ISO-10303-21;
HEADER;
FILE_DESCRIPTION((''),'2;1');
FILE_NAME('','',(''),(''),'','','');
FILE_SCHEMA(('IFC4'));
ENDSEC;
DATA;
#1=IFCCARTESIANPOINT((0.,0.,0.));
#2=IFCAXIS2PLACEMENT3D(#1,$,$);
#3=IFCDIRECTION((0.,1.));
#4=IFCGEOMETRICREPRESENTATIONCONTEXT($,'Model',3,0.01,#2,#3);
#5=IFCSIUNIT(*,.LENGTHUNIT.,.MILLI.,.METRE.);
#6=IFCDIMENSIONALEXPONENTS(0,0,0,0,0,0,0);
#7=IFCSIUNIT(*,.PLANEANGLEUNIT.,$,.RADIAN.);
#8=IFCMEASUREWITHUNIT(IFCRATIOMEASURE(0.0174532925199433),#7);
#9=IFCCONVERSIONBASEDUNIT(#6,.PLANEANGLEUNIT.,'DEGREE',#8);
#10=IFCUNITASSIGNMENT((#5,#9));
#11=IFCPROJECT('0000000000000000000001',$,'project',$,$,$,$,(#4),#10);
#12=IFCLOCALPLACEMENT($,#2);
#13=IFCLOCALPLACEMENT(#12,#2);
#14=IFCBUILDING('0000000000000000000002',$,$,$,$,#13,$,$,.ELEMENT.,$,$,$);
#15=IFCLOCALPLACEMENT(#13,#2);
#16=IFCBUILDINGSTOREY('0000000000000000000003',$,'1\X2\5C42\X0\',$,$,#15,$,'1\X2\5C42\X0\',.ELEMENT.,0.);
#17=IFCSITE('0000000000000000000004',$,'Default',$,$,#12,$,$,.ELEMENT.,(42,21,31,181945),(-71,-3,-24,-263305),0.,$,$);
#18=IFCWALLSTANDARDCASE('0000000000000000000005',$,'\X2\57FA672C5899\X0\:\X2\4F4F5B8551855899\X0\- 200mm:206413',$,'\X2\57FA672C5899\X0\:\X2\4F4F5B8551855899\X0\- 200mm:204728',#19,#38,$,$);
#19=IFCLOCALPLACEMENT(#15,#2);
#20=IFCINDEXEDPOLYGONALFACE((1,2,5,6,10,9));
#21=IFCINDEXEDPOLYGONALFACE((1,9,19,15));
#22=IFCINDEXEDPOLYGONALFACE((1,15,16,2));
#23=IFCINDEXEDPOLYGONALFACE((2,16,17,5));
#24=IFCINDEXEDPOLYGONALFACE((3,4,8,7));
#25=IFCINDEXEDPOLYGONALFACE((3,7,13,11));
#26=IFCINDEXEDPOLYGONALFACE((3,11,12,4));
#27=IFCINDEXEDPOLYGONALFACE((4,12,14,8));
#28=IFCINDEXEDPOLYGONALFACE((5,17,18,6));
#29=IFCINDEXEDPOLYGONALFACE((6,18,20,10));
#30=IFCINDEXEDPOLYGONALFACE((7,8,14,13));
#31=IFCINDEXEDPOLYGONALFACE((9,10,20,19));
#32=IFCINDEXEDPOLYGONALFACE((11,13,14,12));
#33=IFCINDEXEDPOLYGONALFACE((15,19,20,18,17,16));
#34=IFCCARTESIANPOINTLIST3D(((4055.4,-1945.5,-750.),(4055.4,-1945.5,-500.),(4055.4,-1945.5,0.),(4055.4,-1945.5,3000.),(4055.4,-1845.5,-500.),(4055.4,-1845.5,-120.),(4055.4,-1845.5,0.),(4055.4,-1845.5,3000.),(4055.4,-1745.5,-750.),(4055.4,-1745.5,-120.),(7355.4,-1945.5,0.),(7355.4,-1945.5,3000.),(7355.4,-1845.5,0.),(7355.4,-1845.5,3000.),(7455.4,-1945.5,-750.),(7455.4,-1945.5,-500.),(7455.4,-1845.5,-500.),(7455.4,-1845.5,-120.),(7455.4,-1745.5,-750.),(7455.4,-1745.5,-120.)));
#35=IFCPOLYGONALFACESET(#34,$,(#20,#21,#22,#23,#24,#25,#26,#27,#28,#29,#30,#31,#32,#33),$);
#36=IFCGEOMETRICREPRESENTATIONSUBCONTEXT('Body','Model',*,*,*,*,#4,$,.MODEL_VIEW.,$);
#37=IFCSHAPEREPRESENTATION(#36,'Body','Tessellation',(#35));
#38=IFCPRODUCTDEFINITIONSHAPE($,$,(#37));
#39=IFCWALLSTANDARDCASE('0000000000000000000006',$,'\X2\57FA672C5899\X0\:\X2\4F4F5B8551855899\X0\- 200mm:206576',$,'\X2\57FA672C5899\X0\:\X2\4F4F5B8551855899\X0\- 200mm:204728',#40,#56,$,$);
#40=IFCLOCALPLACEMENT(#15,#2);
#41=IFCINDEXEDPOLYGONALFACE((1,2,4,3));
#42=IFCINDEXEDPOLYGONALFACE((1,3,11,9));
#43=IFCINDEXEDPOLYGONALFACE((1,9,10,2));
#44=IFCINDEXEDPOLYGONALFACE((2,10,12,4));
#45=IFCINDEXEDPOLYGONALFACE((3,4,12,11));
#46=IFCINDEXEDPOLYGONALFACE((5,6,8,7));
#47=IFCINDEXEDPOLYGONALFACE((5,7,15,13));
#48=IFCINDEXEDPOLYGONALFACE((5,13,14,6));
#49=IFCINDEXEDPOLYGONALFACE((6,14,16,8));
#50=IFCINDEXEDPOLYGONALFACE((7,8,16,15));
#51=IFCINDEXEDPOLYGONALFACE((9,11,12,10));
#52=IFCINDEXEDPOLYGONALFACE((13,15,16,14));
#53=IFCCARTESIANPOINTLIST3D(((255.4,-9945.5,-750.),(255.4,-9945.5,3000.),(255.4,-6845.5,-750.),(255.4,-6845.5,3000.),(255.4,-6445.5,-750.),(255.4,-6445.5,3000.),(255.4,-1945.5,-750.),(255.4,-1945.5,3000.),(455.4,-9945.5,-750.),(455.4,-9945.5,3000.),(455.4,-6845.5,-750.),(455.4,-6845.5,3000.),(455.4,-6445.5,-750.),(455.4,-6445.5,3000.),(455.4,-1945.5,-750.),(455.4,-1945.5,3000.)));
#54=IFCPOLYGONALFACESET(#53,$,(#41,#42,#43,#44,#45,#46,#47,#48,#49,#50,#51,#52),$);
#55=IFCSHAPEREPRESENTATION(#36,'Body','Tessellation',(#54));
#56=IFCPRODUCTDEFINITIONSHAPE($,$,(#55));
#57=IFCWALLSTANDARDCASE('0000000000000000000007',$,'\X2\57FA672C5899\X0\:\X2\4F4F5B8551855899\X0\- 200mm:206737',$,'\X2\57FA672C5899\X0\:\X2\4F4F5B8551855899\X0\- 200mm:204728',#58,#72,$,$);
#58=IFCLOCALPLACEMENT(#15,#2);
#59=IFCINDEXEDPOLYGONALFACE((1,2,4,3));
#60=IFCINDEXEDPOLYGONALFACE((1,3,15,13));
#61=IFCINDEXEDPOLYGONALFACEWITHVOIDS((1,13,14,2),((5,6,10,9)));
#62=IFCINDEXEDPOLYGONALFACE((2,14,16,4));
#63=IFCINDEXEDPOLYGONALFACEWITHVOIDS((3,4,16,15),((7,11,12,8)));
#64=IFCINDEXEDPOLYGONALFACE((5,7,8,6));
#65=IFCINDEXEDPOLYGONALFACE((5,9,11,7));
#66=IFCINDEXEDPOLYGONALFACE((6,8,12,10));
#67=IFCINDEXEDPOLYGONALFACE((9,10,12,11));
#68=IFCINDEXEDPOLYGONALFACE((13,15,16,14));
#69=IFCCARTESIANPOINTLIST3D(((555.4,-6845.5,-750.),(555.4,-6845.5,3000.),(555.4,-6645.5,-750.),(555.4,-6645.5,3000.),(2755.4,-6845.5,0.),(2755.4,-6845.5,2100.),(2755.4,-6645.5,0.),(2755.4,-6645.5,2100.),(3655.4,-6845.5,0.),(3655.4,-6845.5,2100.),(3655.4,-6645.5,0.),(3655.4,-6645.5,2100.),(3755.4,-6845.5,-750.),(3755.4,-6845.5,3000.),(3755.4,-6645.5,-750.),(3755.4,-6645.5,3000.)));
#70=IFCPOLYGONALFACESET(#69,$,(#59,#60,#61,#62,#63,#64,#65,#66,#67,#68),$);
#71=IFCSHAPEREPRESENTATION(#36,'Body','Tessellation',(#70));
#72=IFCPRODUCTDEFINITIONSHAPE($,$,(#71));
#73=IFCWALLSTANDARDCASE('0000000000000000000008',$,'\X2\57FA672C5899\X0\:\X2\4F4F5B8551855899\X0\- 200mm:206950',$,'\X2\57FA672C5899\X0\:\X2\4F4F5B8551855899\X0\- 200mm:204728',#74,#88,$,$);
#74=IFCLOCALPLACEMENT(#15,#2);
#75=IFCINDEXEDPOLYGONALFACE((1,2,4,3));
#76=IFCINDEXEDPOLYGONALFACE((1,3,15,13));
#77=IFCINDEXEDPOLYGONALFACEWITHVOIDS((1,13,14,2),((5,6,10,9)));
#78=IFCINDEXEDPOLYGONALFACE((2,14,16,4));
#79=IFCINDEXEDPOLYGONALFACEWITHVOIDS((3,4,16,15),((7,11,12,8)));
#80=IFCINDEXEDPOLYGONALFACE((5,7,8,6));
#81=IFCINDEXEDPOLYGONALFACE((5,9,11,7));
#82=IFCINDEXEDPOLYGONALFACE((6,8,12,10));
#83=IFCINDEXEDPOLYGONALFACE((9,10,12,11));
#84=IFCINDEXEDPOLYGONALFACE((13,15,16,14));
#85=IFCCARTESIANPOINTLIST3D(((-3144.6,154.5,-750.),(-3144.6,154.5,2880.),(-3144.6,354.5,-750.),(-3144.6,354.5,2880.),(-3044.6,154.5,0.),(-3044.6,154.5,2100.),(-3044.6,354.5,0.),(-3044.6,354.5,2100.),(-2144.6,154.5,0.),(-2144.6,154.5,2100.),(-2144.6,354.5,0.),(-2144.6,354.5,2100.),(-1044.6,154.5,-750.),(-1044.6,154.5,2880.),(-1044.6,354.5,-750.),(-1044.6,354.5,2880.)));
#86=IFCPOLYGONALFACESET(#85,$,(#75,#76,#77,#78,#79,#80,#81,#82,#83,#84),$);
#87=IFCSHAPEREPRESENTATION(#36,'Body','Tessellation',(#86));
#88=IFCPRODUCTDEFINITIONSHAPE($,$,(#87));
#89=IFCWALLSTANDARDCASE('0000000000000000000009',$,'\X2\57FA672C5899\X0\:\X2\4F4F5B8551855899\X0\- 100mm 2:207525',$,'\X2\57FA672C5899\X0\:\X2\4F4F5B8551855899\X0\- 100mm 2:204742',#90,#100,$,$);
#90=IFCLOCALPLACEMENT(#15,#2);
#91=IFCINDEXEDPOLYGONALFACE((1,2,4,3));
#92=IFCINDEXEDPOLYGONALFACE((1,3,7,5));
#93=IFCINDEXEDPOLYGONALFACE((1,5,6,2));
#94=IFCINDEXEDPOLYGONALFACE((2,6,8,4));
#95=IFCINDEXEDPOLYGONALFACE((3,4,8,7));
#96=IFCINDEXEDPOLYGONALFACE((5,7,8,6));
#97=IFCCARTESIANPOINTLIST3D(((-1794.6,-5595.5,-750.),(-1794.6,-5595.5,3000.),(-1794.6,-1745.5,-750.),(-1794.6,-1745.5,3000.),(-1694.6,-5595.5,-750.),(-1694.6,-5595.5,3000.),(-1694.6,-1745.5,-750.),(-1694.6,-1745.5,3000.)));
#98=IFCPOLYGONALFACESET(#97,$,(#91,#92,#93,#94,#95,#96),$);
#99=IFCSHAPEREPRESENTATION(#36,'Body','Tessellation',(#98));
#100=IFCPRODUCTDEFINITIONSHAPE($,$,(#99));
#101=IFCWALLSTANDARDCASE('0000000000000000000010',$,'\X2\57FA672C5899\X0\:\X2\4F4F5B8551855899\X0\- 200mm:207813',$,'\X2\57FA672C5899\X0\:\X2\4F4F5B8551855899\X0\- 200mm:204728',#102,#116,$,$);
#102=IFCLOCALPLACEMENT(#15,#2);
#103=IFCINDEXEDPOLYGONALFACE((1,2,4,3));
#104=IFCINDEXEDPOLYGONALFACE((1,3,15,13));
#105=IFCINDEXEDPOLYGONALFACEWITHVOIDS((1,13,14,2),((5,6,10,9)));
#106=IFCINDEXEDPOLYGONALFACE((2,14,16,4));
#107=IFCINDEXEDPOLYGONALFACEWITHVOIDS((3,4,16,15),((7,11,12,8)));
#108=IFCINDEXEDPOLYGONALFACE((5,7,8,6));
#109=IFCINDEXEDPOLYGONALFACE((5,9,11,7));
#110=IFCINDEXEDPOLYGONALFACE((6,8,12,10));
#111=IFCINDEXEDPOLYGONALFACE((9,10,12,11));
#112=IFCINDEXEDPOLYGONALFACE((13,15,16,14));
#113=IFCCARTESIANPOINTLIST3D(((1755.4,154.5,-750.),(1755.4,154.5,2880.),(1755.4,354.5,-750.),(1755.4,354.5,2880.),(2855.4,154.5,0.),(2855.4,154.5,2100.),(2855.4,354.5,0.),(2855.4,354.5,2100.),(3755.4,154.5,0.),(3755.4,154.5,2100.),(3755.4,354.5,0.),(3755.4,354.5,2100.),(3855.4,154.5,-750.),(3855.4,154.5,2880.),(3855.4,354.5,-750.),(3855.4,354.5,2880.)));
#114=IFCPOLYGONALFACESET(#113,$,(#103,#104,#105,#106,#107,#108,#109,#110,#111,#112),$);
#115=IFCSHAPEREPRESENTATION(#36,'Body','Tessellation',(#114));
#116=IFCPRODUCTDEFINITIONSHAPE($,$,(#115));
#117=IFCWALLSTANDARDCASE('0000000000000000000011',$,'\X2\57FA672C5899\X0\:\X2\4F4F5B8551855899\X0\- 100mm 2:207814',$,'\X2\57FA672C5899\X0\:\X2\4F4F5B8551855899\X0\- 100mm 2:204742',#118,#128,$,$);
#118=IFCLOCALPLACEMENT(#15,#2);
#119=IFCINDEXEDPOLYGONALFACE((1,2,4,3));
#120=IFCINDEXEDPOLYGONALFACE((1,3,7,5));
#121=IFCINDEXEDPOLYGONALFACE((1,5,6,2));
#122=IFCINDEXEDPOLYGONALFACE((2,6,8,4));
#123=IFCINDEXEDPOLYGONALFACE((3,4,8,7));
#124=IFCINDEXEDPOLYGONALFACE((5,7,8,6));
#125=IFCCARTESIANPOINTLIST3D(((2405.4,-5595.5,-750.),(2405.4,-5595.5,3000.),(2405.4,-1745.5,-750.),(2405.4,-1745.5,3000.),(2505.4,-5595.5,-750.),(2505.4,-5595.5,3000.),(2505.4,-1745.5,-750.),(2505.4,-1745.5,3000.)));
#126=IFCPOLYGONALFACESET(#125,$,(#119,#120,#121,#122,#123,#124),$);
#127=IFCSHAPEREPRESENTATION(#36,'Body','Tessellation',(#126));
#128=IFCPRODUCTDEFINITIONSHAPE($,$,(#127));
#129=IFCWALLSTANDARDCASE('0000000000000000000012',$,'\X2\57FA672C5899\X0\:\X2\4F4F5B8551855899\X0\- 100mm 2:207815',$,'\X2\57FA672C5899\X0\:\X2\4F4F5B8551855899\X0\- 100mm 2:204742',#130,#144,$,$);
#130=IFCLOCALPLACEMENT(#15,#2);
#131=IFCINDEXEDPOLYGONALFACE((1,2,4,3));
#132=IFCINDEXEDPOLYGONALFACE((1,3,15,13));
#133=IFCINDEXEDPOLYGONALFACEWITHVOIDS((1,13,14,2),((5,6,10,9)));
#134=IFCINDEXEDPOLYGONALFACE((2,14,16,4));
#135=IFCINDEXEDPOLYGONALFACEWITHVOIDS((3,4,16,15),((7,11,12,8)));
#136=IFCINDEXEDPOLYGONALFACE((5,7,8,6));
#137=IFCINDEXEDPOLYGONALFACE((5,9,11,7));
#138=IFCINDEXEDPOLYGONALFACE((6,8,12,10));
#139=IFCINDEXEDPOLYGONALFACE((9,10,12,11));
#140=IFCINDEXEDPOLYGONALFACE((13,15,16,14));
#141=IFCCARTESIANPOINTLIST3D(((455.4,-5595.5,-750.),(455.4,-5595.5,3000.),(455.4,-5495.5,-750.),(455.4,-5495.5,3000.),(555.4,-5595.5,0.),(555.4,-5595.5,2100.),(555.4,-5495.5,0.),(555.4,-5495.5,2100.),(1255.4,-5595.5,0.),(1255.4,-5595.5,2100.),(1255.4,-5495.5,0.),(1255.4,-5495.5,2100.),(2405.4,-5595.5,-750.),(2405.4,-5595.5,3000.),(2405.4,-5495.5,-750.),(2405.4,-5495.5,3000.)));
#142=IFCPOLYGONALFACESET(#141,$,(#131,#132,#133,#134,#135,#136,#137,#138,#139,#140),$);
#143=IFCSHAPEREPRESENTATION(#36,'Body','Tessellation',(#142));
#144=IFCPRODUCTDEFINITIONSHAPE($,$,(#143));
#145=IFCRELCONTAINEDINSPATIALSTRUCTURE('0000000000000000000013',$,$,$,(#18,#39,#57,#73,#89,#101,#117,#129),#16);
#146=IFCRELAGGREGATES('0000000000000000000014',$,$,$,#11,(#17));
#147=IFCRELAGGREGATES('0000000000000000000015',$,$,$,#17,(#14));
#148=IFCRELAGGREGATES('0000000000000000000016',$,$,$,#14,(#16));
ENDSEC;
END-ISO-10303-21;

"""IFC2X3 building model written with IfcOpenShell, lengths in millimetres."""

from ifc_helpers import new_model, entity, si_unit, converted_unit, direction, frame, frame_2d, origin, place, context, subcontext, project, spatial, polyline, rectangle, extrude, clip, bounded_halfspace, element, save


model = new_model("IFC2X3")

# Units and contexts
model_context = context("Model", 3, precision=0.01, world=origin(), true_north=direction((0.0, 1.0)))
body_context = subcontext(model_context, "Body", "Model", "MODEL_VIEW")
ifc_project = project(units=[si_unit("LENGTHUNIT", "METRE", prefix="MILLI"), converted_unit("PLANEANGLEUNIT", "DEGREE", entity("IfcRatioMeasure", 0.0174532925199433), si_unit("PLANEANGLEUNIT", "RADIAN"), dimensions=[0, 0, 0, 0, 0, 0, 0])], contexts=[model_context])

# Site, building, storey
site_placement = place(None, origin())
site = spatial("IfcSite", under=ifc_project, at=site_placement, Name="Default", CompositionType="ELEMENT", RefLatitude=(42, 21, 31, 181945), RefLongitude=(-71, -3, -24, -263305), RefElevation=0.0)
building_placement = place(site_placement, origin())
building = spatial("IfcBuilding", under=site, at=building_placement, CompositionType="ELEMENT")
storey_placement = place(building_placement, origin())
storey = spatial("IfcBuildingStorey", under=building, at=storey_placement, Name="1层", LongName="1层", CompositionType="ELEMENT", Elevation=0.0)

# Walls, openings
wall_1_placement = place(storey_placement, frame((4055.4, -1845.5, -750.0)))
wall_1 = element("IfcWallStandardCase", 1, at=wall_1_placement, inside=storey, Name="基本墙:住宅内墙- 200mm:206413", ObjectType="基本墙:住宅内墙- 200mm:204728", context=body_context, shape_type="Clipping", body=[
    clip(clip(extrude(rectangle(XDim=3400.0, YDim=200.0, at=frame_2d((1700.0, 0.0), x_axis=(-1.0, 0.0))), origin(), (0.0, 0.0, 1.0), 3750.0), bounded_halfspace(frame((3300.0, -100.0, 3750.0), z_axis=(-1.0, 0.0, 0.0), x_axis=(0.0, 0.0, -1.0)), True, frame((3300.0, -100.0, 3750.0), z_axis=(-1.0, 0.0, 0.0), x_axis=(0.0, 0.0, -1.0)), polyline([(0.0, 0.0), (0.0, -200.0), (3000.0, -200.0), (3000.0, 0.0), (0.0, 0.0)]))), bounded_halfspace(frame((3400.0, 100.0, 630.0), z_axis=(0.0, 0.0, -1.0), x_axis=(1.0, 0.0, 0.0)), True, frame((3400.0, 100.0, 630.0), z_axis=(0.0, 0.0, -1.0), x_axis=(1.0, 0.0, 0.0)), polyline([(0.0, 0.0), (0.0, 100.0), (-3400.0, 100.0), (-3400.0, 0.0), (0.0, 0.0)]))),
])
opening_1_placement = place(storey_placement, frame((4055.4, -1845.5, -750.0)))
element("IfcOpeningElement", 2, at=opening_1_placement, cuts=wall_1, ObjectType="Opening", context=body_context, shape_type="SweptSolid", body=[
    extrude(rectangle(XDim=3400.0, YDim=100.0, at=frame_2d((0.0, 0.0), x_axis=(1.0, 0.0))), frame((1700.0, -50.0, 250.0), z_axis=(0.0, 0.0, 1.0), x_axis=(-1.0, 0.0, 0.0)), (0.0, 0.0, 1.0), 500.0),
])
wall_2_placement = place(storey_placement, frame((355.4, -1945.5, -750.0), z_axis=(0.0, 0.0, 1.0), x_axis=(0.0, -1.0, 0.0)))
wall_2 = element("IfcWallStandardCase", 3, at=wall_2_placement, inside=storey, Name="基本墙:住宅内墙- 200mm:206576", ObjectType="基本墙:住宅内墙- 200mm:204728", context=body_context, shape_type="Clipping", body=[
    clip(extrude(rectangle(XDim=8000.0, YDim=200.0, at=frame_2d((4000.0, 0.0), x_axis=(-1.0, 0.0))), origin(), (0.0, 0.0, 1.0), 3750.0), bounded_halfspace(frame((8000.0, -100.0, 3750.0), z_axis=(-1.0, 0.0, 0.0), x_axis=(0.0, 0.0, -1.0)), True, frame((8000.0, -100.0, 3750.0), z_axis=(-1.0, 0.0, 0.0), x_axis=(0.0, 0.0, -1.0)), polyline([(0.0, 0.0), (0.0, -200.0), (3750.0, -200.0), (3750.0, 0.0), (0.0, 0.0)]))),
])
opening_2_placement = place(storey_placement, frame((355.4, -1945.5, -750.0), z_axis=(0.0, 0.0, 1.0), x_axis=(0.0, -1.0, 0.0)))
element("IfcOpeningElement", 4, at=opening_2_placement, cuts=wall_2, ObjectType="Opening", context=body_context, shape_type="SweptSolid", body=[
    extrude(rectangle(XDim=3750.0, YDim=200.0, at=frame_2d((0.0, 0.0), x_axis=(1.0, 0.0))), frame((4900.0, 0.0, 1875.0), z_axis=(-1.0, 0.0, 0.0), x_axis=(0.0, 0.0, 1.0)), (0.0, 0.0, 1.0), 400.0),
])
wall_3_placement = place(storey_placement, frame((3755.4, -6745.5, -750.0), z_axis=(0.0, 0.0, 1.0), x_axis=(-1.0, 0.0, 0.0)))
wall_3 = element("IfcWallStandardCase", 5, at=wall_3_placement, inside=storey, Name="基本墙:住宅内墙- 200mm:206737", ObjectType="基本墙:住宅内墙- 200mm:204728", context=body_context, shape_type="Clipping", body=[
    clip(clip(extrude(rectangle(XDim=3200.0, YDim=200.0, at=frame_2d((1600.0, 0.0), x_axis=(-1.0, 0.0))), origin(), (0.0, 0.0, 1.0), 3750.0), bounded_halfspace(frame((0.0, -100.0, 0.0), z_axis=(-1.0, 0.0, 0.0), x_axis=(0.0, 0.0, -1.0)), False, frame((0.0, -100.0, 0.0), z_axis=(-1.0, 0.0, 0.0), x_axis=(0.0, 0.0, -1.0)), polyline([(0.0, 0.0), (-3750.0, 0.0), (-3750.0, -200.0), (0.0, -200.0), (0.0, 0.0)]))), bounded_halfspace(frame((3200.0, -100.0, 3750.0), z_axis=(-1.0, 0.0, 0.0), x_axis=(0.0, 0.0, -1.0)), True, frame((3200.0, -100.0, 3750.0), z_axis=(-1.0, 0.0, 0.0), x_axis=(0.0, 0.0, -1.0)), polyline([(0.0, 0.0), (0.0, -200.0), (3750.0, -200.0), (3750.0, 0.0), (0.0, 0.0)]))),
])
opening_3_placement = place(wall_3_placement, frame((100.0, -100.0, 750.0)))
element("IfcOpeningElement", 6, at=opening_3_placement, cuts=wall_3, ObjectType="Opening", context=body_context, shape_type="SweptSolid", body=[
    extrude(rectangle(XDim=2100.0, YDim=900.0, at=frame_2d((1050.0, 450.0), x_axis=(1.0, 0.0))), frame((0.0, 0.0, 0.0), z_axis=(0.0, 1.0, 0.0), x_axis=(0.0, 0.0, 1.0)), (0.0, 0.0, 1.0), 200.0),
])
wall_4_placement = place(storey_placement, frame((-3144.6, 254.5, -750.0)))
wall_4 = element("IfcWallStandardCase", 7, at=wall_4_placement, inside=storey, Name="基本墙:住宅内墙- 200mm:206950", ObjectType="基本墙:住宅内墙- 200mm:204728", context=body_context, shape_type="SweptSolid", body=[
    extrude(rectangle(XDim=2100.0, YDim=200.0, at=frame_2d((1050.0, 0.0), x_axis=(-1.0, 0.0))), origin(), (0.0, 0.0, 1.0), 3630.0),
])
opening_4_placement = place(wall_4_placement, frame((100.0, -100.0, 750.0)))
element("IfcOpeningElement", 8, at=opening_4_placement, cuts=wall_4, ObjectType="Opening", context=body_context, shape_type="SweptSolid", body=[
    extrude(rectangle(XDim=2100.0, YDim=900.0, at=frame_2d((1050.0, 450.0), x_axis=(1.0, 0.0))), frame((0.0, 0.0, 0.0), z_axis=(0.0, 1.0, 0.0), x_axis=(0.0, 0.0, 1.0)), (0.0, 0.0, 1.0), 200.0),
])

# Wall
wall_5_placement = place(storey_placement, frame((-1744.6, -1745.5, -750.0), z_axis=(0.0, 0.0, 1.0), x_axis=(0.0, -1.0, 0.0)))
element("IfcWallStandardCase", 9, at=wall_5_placement, inside=storey, Name="基本墙:住宅内墙- 100mm 2:207525", ObjectType="基本墙:住宅内墙- 100mm 2:204742", context=body_context, shape_type="SweptSolid", body=[
    extrude(rectangle(XDim=3850.0, YDim=100.0, at=frame_2d((1925.0, 0.0), x_axis=(-1.0, 0.0))), origin(), (0.0, 0.0, 1.0), 3750.0),
])

# Wall, opening
wall_6_placement = place(storey_placement, frame((3855.4, 254.5, -750.0), z_axis=(0.0, 0.0, 1.0), x_axis=(-1.0, 0.0, 0.0)))
wall_6 = element("IfcWallStandardCase", 10, at=wall_6_placement, inside=storey, Name="基本墙:住宅内墙- 200mm:207813", ObjectType="基本墙:住宅内墙- 200mm:204728", context=body_context, shape_type="SweptSolid", body=[
    extrude(rectangle(XDim=2100.0, YDim=200.0, at=frame_2d((1050.0, 0.0), x_axis=(-1.0, 0.0))), origin(), (0.0, 0.0, 1.0), 3630.0),
])
opening_5_placement = place(wall_6_placement, frame((1000.0, 100.0, 750.0)))
element("IfcOpeningElement", 11, at=opening_5_placement, cuts=wall_6, ObjectType="Opening", context=body_context, shape_type="SweptSolid", body=[
    extrude(rectangle(XDim=2100.0, YDim=900.0, at=frame_2d((1050.0, 450.0), x_axis=(1.0, 0.0))), frame((0.0, 0.0, 0.0), z_axis=(0.0, -1.0, 0.0), x_axis=(0.0, 0.0, 1.0)), (0.0, 0.0, 1.0), 200.0),
])

# Wall
wall_7_placement = place(storey_placement, frame((2455.4, -1745.5, -750.0), z_axis=(0.0, 0.0, 1.0), x_axis=(0.0, -1.0, 0.0)))
element("IfcWallStandardCase", 12, at=wall_7_placement, inside=storey, Name="基本墙:住宅内墙- 100mm 2:207814", ObjectType="基本墙:住宅内墙- 100mm 2:204742", context=body_context, shape_type="SweptSolid", body=[
    extrude(rectangle(XDim=3850.0, YDim=100.0, at=frame_2d((1925.0, 0.0), x_axis=(-1.0, 0.0))), origin(), (0.0, 0.0, 1.0), 3750.0),
])

# Wall, opening
wall_8_placement = place(storey_placement, frame((2405.4, -5545.5, -750.0), z_axis=(0.0, 0.0, 1.0), x_axis=(-1.0, 0.0, 0.0)))
wall_8 = element("IfcWallStandardCase", 13, at=wall_8_placement, inside=storey, Name="基本墙:住宅内墙- 100mm 2:207815", ObjectType="基本墙:住宅内墙- 100mm 2:204742", context=body_context, shape_type="SweptSolid", body=[
    extrude(rectangle(XDim=1950.0, YDim=100.0, at=frame_2d((975.0, 0.0), x_axis=(-1.0, 0.0))), origin(), (0.0, 0.0, 1.0), 3750.0),
])
opening_6_placement = place(wall_8_placement, frame((1850.0, 50.0, 750.0)))
element("IfcOpeningElement", 14, at=opening_6_placement, cuts=wall_8, ObjectType="Opening", context=body_context, shape_type="SweptSolid", body=[
    extrude(rectangle(XDim=2100.0, YDim=700.0, at=frame_2d((1050.0, 350.0), x_axis=(1.0, 0.0))), frame((0.0, 0.0, 0.0), z_axis=(0.0, -1.0, 0.0), x_axis=(0.0, 0.0, 1.0)), (0.0, 0.0, 1.0), 100.0),
])

save(model, "model.ifc")
